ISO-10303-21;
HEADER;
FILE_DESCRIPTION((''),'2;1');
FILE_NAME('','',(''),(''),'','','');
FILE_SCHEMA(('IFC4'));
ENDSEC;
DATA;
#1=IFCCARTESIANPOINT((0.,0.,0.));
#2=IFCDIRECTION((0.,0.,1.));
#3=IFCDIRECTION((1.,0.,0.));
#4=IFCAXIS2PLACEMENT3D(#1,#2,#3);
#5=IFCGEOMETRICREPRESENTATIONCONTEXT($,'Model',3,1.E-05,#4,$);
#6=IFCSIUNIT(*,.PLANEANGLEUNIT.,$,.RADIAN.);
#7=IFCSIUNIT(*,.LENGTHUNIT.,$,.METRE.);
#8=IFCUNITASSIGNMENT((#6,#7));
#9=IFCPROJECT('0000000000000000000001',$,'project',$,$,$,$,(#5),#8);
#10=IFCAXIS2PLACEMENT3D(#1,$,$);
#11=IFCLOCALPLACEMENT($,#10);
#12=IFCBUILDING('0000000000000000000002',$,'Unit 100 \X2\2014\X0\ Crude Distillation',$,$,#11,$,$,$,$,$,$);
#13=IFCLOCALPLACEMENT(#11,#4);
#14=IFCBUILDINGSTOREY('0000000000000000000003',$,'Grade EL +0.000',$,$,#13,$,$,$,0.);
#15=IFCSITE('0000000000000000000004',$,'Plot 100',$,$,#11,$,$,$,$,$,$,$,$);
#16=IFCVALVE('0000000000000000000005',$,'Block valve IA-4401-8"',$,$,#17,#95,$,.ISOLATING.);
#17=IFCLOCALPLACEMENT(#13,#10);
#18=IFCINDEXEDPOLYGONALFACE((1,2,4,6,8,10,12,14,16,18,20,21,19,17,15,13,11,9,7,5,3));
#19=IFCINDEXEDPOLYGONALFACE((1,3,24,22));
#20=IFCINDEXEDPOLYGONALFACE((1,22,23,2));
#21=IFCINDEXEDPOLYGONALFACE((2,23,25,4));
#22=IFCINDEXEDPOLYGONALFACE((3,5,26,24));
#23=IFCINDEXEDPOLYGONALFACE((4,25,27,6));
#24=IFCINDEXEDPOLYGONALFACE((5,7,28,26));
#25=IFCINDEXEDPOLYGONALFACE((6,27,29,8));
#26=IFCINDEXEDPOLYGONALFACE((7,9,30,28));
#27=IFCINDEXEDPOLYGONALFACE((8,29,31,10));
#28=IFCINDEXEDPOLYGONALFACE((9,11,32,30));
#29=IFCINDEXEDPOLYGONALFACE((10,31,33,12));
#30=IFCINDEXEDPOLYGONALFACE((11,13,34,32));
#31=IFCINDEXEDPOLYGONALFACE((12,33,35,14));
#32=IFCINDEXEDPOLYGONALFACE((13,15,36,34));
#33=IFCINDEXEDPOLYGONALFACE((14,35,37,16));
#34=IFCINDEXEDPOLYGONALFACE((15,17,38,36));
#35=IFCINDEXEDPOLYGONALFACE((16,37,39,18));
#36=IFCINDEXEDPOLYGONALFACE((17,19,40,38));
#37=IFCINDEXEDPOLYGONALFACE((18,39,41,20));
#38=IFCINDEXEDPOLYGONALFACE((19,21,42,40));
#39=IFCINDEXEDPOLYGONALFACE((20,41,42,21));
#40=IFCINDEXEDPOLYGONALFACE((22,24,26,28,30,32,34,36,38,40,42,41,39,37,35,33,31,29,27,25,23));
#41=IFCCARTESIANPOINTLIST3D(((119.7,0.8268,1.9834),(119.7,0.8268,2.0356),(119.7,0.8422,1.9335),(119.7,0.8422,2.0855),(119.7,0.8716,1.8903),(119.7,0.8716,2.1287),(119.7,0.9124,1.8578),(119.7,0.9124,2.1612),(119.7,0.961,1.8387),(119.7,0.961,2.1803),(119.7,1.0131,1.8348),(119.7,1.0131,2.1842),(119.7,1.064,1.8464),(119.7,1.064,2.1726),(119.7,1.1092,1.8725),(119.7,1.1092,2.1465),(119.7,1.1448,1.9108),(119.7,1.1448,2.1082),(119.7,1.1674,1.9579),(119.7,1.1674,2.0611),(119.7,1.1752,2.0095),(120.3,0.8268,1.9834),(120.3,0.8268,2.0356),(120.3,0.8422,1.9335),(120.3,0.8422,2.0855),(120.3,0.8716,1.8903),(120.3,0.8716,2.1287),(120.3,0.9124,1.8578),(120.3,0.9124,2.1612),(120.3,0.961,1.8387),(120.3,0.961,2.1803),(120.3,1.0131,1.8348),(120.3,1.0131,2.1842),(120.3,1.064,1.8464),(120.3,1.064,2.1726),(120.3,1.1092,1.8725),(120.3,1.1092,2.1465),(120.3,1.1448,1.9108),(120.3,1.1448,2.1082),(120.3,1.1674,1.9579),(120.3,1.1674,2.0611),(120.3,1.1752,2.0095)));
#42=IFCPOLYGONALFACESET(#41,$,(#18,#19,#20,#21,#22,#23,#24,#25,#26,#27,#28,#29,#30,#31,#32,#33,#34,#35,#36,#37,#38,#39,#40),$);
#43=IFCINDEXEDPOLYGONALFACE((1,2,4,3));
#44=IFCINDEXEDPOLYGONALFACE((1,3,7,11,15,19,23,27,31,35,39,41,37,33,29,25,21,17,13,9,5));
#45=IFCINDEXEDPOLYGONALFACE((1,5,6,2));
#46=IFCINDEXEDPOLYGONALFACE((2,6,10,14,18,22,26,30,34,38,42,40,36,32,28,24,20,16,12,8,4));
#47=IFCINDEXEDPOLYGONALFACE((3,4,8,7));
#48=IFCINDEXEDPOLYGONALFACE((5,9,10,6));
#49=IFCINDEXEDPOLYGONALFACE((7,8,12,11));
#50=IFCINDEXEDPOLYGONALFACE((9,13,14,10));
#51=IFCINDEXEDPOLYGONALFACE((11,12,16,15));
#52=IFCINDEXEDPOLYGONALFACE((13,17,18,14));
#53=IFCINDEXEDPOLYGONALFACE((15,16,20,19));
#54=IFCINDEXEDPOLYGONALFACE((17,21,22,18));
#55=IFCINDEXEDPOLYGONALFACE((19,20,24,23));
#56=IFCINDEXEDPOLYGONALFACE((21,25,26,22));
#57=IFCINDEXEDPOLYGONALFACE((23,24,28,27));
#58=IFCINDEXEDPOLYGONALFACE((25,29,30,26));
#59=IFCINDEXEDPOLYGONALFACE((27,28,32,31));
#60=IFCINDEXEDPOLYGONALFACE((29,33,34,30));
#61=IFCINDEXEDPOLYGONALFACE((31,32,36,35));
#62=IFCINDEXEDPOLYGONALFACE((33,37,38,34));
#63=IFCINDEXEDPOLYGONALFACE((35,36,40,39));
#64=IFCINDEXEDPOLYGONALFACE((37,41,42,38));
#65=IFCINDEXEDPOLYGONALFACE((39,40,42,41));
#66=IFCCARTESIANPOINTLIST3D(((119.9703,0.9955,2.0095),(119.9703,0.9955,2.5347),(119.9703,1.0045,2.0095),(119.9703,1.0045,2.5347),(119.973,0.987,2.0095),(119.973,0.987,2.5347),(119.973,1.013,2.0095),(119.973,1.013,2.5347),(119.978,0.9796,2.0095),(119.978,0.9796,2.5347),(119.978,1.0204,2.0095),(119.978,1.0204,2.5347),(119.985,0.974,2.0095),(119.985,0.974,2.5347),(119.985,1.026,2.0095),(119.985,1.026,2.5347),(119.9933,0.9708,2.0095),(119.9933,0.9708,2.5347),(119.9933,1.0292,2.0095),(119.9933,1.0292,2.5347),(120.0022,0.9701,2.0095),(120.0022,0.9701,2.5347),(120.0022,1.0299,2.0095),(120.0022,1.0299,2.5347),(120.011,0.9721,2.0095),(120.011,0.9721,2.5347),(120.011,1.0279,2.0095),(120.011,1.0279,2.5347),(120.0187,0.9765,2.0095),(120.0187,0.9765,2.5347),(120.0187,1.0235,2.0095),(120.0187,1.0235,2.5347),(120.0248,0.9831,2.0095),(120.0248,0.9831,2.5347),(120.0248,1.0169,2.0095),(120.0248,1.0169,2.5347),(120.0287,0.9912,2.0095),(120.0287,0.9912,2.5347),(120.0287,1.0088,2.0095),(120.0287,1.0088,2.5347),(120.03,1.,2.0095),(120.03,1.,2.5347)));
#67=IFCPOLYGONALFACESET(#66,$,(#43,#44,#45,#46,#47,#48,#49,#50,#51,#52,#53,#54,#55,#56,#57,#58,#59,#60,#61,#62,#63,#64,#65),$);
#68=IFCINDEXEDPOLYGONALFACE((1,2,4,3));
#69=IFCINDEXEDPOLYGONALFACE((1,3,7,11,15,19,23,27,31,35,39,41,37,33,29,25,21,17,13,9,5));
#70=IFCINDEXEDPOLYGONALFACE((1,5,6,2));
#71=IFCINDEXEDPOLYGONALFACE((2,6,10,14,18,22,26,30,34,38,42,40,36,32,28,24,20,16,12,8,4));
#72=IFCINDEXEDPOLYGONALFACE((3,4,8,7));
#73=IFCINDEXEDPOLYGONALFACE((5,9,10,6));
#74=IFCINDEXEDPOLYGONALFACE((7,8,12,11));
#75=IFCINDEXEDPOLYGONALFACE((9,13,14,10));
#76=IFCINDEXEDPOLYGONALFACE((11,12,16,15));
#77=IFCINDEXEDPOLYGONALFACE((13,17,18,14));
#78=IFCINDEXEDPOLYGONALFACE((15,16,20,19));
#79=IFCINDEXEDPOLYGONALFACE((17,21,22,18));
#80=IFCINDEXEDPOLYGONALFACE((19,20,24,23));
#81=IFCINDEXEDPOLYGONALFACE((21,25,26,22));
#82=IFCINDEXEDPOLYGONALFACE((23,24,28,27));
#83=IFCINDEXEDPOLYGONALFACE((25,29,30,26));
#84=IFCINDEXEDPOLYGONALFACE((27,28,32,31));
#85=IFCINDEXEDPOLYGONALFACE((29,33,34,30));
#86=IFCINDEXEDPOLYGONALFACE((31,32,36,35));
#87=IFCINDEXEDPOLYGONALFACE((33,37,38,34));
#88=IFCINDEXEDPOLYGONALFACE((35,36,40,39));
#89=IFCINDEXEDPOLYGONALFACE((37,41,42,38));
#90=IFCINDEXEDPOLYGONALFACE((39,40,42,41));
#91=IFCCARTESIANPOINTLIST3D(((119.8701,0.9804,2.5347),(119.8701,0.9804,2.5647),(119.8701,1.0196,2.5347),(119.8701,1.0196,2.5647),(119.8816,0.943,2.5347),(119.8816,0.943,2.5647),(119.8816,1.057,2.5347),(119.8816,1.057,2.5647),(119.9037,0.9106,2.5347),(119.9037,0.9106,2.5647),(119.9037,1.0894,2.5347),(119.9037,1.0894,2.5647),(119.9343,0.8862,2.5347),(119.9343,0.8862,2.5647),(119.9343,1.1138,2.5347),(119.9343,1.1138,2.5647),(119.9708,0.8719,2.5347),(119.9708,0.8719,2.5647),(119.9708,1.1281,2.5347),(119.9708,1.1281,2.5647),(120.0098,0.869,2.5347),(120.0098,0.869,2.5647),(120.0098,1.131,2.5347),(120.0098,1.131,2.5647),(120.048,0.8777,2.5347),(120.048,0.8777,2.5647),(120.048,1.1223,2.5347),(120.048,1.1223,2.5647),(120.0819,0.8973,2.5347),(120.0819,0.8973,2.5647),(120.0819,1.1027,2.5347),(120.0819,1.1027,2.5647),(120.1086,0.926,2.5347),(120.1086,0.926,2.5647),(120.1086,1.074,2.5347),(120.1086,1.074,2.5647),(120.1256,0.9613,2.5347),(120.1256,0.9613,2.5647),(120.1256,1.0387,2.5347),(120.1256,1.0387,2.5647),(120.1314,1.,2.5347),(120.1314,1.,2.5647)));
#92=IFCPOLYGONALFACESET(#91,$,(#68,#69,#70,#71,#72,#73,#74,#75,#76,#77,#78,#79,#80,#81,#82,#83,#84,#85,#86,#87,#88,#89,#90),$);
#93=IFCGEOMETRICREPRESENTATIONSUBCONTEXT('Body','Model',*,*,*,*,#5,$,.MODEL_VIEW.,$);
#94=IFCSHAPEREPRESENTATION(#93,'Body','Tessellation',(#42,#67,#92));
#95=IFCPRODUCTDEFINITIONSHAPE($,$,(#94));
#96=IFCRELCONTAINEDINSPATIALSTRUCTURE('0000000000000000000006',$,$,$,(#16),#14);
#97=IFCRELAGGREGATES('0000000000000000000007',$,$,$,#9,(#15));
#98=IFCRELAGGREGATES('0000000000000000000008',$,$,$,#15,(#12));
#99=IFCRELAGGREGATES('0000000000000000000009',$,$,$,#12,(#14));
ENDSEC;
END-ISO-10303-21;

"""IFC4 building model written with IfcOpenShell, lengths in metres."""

from ifc_helpers import new_model, si_unit, frame, origin, origin_with_axes, origin_2d, place, context, subcontext, project, spatial, circle, extrude, element, save


model = new_model("IFC4")

# Units and contexts
model_context = context("Model", 3, precision=1e-05, world=origin_with_axes())
body_context = subcontext(model_context, "Body", "Model", "MODEL_VIEW")
ifc_project = project(units=[si_unit("PLANEANGLEUNIT", "RADIAN"), si_unit("LENGTHUNIT", "METRE")], contexts=[model_context])

# Site, building, storey
placement = place(None, origin())
site = spatial("IfcSite", under=ifc_project, at=placement, Name="Plot 100")
building = spatial("IfcBuilding", under=site, at=placement, Name="Unit 100 — Crude Distillation")
storey_placement = place(placement, origin_with_axes())
storey = spatial("IfcBuildingStorey", under=building, at=storey_placement, Name="Grade EL +0.000", Elevation=0.0)

# Valve
valve_1_placement = place(storey_placement, origin_with_axes())
element("IfcValve", 1, at=valve_1_placement, inside=storey, Name="Block valve IA-4401-8\"", PredefinedType="ISOLATING", context=body_context, shape_type="SweptSolid", body=[
    extrude(circle(Radius=0.1752, at=origin_2d()), frame((119.7, 1.0, 2.0095), z_axis=(1.0, 0.0, 0.0), x_axis=(0.0, 1.0, 0.0)), (0.0, 0.0, 1.0), 0.6),
    extrude(circle(Radius=0.03, at=origin_2d()), frame((120.0, 1.0, 2.0095), z_axis=(0.0, 0.0, 1.0), x_axis=(1.0, 0.0, 0.0)), (0.0, 0.0, 1.0), 0.5252),
    extrude(circle(Radius=0.1314, at=origin_2d()), frame((120.0, 1.0, 2.5347), z_axis=(0.0, 0.0, 1.0), x_axis=(1.0, 0.0, 0.0)), (0.0, 0.0, 1.0), 0.03),
])

save(model, "model.ifc")
